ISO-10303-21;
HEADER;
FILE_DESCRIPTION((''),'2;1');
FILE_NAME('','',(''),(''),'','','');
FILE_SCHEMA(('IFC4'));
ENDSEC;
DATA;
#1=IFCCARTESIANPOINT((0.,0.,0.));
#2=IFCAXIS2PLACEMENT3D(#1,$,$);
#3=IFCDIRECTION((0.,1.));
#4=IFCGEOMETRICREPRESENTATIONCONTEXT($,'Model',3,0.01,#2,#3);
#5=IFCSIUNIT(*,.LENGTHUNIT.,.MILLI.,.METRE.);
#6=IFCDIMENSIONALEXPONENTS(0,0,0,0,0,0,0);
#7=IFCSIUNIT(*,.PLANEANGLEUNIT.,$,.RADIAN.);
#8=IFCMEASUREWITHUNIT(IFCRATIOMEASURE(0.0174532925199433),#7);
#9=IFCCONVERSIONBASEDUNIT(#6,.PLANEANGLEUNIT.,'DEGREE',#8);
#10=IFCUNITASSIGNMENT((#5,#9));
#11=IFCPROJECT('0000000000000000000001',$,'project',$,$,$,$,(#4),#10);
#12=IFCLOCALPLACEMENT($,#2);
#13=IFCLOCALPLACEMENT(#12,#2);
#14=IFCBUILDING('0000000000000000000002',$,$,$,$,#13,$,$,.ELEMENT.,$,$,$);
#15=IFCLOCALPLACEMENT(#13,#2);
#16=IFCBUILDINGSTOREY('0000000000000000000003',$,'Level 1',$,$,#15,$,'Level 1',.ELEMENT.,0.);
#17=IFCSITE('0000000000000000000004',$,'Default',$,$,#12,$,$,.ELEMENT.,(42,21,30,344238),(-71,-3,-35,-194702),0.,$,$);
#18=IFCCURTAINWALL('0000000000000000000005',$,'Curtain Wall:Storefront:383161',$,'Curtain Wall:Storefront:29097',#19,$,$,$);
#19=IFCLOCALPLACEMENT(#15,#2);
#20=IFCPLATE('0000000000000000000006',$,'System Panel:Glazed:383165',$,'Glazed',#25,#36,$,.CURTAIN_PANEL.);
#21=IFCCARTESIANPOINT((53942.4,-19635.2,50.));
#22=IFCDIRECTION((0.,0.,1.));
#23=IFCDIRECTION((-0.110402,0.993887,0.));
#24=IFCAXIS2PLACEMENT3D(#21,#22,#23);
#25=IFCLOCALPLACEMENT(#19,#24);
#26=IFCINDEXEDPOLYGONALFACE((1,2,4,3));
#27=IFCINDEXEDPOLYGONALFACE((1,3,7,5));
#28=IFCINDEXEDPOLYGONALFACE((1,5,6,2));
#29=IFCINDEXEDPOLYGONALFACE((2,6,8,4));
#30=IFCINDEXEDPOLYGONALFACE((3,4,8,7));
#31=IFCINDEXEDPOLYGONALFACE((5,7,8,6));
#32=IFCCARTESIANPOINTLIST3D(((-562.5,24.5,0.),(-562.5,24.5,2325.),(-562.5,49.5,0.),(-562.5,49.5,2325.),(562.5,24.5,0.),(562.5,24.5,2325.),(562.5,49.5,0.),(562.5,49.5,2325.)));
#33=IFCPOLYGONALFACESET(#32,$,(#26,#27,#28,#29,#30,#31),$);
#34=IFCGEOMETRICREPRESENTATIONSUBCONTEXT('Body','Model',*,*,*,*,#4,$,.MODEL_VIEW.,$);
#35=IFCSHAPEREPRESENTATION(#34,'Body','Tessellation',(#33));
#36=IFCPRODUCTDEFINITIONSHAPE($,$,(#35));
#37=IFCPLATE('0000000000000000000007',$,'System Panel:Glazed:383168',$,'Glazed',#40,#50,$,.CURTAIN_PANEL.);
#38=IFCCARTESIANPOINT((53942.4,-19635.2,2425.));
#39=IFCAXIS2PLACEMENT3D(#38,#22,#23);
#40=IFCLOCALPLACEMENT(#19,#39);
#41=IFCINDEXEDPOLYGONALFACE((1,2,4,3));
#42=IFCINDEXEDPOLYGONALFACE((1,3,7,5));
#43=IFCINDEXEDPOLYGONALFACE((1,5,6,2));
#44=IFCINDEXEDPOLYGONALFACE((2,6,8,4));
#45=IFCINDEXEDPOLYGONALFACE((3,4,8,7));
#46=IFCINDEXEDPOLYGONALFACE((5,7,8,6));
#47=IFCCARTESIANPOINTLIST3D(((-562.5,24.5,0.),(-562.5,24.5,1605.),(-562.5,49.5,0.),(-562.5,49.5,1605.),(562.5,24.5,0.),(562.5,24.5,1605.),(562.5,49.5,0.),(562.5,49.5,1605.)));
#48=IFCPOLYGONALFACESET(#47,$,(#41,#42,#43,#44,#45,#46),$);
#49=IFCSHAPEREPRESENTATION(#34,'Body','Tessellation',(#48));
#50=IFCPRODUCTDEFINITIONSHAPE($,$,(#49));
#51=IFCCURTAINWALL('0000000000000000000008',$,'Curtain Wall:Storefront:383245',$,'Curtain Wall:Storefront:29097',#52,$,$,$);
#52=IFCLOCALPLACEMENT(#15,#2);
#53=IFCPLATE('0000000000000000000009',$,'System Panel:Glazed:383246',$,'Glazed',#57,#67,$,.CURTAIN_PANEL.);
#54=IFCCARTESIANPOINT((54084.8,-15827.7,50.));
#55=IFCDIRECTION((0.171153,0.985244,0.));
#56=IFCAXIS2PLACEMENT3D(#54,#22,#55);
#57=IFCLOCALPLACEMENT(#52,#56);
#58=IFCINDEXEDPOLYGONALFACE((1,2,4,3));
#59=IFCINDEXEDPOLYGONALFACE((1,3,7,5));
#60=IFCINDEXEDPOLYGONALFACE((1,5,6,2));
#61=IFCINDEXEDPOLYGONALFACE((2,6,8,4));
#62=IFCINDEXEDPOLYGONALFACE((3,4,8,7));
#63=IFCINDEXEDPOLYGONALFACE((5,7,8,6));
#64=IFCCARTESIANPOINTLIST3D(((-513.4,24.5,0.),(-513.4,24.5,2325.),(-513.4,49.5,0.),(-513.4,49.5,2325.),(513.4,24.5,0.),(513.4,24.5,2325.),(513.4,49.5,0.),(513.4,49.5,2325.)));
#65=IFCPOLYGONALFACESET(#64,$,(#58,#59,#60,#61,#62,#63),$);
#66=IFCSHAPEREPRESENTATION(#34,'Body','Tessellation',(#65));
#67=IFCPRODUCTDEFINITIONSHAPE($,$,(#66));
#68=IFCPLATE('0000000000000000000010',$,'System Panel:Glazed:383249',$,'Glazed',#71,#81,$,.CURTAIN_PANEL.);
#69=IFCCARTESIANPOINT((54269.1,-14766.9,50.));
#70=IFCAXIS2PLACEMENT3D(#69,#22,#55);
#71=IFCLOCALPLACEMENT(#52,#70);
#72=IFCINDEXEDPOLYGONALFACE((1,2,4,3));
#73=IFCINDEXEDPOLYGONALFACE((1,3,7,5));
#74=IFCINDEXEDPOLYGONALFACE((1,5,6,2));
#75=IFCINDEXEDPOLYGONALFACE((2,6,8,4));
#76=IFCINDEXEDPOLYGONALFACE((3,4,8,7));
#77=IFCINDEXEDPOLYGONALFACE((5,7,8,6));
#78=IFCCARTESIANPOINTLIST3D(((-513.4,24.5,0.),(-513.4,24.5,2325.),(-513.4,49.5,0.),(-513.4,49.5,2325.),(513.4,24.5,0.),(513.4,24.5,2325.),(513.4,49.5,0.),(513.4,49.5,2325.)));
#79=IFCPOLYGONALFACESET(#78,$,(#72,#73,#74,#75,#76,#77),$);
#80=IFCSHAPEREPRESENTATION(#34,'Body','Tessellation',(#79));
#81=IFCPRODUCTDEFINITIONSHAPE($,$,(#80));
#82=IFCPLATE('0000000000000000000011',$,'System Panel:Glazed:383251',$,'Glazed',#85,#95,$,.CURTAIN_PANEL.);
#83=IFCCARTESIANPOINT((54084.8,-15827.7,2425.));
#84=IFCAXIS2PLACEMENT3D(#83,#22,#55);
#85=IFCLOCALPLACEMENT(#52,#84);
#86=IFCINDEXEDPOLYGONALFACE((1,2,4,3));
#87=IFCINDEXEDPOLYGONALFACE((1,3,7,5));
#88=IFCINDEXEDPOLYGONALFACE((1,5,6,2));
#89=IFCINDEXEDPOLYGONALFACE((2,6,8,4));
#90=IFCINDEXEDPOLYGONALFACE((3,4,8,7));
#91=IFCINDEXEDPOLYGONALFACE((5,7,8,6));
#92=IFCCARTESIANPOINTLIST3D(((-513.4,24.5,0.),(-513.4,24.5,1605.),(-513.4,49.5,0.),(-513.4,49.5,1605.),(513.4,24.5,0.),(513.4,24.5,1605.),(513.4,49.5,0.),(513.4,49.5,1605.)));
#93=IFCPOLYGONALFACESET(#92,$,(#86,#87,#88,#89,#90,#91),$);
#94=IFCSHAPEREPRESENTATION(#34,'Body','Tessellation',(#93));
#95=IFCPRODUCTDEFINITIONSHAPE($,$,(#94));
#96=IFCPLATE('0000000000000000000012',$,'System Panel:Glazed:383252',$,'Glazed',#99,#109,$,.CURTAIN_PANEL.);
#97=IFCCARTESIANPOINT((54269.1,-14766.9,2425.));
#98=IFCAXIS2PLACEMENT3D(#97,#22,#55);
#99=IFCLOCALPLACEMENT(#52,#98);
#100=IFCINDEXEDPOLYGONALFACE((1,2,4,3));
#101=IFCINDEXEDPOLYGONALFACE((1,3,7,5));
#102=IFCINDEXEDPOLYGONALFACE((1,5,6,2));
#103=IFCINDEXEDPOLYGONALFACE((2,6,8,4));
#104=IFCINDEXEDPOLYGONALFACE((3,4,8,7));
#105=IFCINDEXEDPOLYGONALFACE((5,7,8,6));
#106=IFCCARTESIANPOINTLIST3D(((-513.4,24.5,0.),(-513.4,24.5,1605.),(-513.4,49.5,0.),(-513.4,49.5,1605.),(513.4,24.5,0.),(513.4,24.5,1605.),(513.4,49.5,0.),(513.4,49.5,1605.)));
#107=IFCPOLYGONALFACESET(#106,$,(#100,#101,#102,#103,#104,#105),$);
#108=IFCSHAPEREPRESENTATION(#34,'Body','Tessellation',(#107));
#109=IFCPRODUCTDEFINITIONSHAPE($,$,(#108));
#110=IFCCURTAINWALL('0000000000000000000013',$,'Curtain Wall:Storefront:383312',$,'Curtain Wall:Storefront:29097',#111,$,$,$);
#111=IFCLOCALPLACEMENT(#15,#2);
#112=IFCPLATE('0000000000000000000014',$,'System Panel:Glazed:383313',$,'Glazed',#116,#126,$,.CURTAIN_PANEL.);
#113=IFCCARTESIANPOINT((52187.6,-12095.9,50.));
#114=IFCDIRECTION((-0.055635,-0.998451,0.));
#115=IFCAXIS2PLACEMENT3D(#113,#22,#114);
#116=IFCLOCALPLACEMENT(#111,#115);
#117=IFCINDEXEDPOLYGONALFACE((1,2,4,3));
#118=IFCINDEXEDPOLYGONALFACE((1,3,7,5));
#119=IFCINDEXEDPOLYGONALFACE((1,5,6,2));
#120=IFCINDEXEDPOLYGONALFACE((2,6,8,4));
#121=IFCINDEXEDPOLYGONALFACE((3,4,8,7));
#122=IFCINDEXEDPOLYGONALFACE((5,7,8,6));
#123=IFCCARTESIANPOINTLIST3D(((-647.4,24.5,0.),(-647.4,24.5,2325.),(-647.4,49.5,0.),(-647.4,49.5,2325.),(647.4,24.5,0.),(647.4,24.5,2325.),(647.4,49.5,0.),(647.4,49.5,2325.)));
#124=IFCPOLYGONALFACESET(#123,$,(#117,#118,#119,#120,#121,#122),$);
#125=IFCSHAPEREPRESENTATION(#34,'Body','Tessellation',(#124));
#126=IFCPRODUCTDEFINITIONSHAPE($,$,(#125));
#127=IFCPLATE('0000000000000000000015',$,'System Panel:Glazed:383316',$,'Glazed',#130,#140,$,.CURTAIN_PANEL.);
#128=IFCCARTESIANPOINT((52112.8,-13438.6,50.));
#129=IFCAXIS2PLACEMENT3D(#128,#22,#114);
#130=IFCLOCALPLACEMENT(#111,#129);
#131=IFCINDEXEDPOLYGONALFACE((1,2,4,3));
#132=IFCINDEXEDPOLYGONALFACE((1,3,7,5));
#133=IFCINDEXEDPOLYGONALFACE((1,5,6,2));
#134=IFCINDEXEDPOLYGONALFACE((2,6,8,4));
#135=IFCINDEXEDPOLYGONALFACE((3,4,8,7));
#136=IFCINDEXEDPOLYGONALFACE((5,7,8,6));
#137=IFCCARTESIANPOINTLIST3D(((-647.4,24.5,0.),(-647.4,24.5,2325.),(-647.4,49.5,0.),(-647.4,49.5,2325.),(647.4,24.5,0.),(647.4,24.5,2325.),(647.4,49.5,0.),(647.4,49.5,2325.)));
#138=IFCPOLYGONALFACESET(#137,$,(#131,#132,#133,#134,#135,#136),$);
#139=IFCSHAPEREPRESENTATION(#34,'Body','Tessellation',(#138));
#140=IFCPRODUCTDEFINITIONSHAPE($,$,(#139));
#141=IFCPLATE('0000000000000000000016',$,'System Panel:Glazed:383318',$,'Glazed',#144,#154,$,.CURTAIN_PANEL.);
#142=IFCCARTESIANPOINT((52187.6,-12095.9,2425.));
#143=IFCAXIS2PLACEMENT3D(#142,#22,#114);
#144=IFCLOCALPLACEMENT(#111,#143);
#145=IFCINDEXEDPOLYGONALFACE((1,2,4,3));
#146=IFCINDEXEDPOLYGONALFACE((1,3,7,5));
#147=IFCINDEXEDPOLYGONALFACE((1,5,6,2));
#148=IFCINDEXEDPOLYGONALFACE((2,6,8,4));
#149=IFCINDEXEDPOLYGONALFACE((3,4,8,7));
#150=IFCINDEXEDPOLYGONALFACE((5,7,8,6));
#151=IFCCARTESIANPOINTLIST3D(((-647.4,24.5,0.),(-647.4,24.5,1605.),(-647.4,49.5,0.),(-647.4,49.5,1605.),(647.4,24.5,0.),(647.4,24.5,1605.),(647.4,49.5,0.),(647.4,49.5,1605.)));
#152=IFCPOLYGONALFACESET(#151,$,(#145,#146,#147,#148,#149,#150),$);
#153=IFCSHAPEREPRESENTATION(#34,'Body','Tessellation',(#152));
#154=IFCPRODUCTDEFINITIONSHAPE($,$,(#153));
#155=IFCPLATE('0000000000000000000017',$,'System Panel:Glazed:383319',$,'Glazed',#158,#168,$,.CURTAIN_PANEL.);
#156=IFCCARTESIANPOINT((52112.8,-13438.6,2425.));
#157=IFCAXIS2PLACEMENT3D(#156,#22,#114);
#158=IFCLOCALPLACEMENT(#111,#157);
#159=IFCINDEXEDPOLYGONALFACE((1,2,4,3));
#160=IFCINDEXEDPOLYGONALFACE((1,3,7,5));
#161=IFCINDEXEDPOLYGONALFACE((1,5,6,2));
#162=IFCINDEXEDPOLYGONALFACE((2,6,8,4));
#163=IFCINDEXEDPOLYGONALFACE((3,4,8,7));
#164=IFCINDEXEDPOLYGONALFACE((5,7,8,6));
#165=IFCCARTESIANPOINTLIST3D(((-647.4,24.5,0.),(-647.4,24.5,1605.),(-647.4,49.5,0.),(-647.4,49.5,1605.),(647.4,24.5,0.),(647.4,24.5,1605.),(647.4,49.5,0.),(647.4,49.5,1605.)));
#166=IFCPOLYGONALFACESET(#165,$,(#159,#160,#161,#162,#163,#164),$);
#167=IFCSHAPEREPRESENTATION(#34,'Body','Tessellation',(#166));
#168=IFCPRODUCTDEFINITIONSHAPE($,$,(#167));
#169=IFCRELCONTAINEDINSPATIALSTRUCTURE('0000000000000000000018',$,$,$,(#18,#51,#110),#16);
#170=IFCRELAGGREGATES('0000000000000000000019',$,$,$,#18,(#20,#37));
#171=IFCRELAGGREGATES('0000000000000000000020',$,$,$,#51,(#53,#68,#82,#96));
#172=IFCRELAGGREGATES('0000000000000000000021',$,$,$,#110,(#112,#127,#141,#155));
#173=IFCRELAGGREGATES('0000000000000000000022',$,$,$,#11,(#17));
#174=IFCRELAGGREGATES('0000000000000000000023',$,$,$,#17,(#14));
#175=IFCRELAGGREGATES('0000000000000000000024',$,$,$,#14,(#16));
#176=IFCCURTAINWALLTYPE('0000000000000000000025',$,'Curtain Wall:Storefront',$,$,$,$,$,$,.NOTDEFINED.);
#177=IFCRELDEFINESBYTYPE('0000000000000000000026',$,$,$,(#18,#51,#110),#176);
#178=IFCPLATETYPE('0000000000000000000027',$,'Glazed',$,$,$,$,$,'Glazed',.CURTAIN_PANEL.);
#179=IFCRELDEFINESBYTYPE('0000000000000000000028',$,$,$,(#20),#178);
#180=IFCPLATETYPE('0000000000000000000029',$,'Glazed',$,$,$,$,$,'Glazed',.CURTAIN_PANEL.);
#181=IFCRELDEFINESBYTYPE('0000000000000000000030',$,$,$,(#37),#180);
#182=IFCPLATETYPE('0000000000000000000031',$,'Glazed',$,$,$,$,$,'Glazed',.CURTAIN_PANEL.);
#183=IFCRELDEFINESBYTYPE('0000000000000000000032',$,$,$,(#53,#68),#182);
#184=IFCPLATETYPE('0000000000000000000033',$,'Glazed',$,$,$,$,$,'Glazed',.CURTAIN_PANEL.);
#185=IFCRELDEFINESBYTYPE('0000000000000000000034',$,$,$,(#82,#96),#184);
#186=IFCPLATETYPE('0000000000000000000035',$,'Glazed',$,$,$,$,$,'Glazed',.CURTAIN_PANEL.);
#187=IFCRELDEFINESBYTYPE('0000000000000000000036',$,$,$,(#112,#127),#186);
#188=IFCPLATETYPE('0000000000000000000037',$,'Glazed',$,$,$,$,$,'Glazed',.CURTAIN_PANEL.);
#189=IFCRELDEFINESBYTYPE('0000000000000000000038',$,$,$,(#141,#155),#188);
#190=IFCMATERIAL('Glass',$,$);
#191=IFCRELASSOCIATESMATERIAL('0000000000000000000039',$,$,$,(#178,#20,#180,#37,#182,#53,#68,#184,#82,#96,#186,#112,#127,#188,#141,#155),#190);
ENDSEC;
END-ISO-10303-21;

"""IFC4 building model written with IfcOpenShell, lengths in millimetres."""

from ifc_helpers import new_model, entity, si_unit, converted_unit, direction, frame, frame_2d, origin, place, context, subcontext, project, spatial, rectangle, extrude, source, transform, mapped, material, type_object, type_shapes, element, aggregate, save


model = new_model("IFC4")

# Units and contexts
model_context = context("Model", 3, precision=0.01, world=origin(), true_north=direction((0.0, 1.0)))
body_context = subcontext(model_context, "Body", "Model", "MODEL_VIEW")
ifc_project = project(units=[si_unit("LENGTHUNIT", "METRE", prefix="MILLI"), converted_unit("PLANEANGLEUNIT", "DEGREE", entity("IfcRatioMeasure", 0.0174532925199433), si_unit("PLANEANGLEUNIT", "RADIAN"), dimensions=[0, 0, 0, 0, 0, 0, 0])], contexts=[model_context])

# Site, building, storey
site_placement = place(None, origin())
site = spatial("IfcSite", under=ifc_project, at=site_placement, Name="Default", CompositionType="ELEMENT", RefLatitude=(42, 21, 30, 344238), RefLongitude=(-71, -3, -35, -194702), RefElevation=0.0)
building_placement = place(site_placement, origin())
building = spatial("IfcBuilding", under=site, at=building_placement, CompositionType="ELEMENT")
storey_placement = place(building_placement, origin())
storey = spatial("IfcBuildingStorey", under=building, at=storey_placement, Name="Level 1", LongName="Level 1", CompositionType="ELEMENT", Elevation=0.0)

# Curtain walls, plates
curtain_wall_type = type_object("IfcCurtainWallType", Name="Curtain Wall:Storefront", PredefinedType="NOTDEFINED")
curtain_wall_1_placement = place(storey_placement, origin())
curtain_wall_1 = element("IfcCurtainWall", 1, at=curtain_wall_1_placement, inside=storey, type_object=curtain_wall_type, Name="Curtain Wall:Storefront:383161", ObjectType="Curtain Wall:Storefront:29097")
ifc_material_1 = material(Name="Glass")
plate_type_1 = type_object("IfcPlateType", Name="Glazed", ElementType="Glazed", PredefinedType="CURTAIN_PANEL", material=ifc_material_1)
shared_shape_1 = source(origin(), body_context, "Body", "SweptSolid", [
    extrude(rectangle(XDim=25.0, YDim=1125.0, at=frame_2d((0.0, 0.0), x_axis=(1.0, 0.0))), frame((0.0, 37.0, 0.0), z_axis=(0.0, 0.0, 1.0), x_axis=(0.0, 1.0, 0.0)), (0.0, 0.0, 1.0), 2325.0),
])
type_shapes(plate_type_1, [shared_shape_1])
plate_1_placement = place(curtain_wall_1_placement, frame((53942.4, -19635.2, 50.0), z_axis=(0.0, 0.0, 1.0), x_axis=(-0.110402, 0.993887, 0.0)))
plate_1 = element("IfcPlate", 2, at=plate_1_placement, type_object=plate_type_1, material=ifc_material_1, Name="System Panel:Glazed:383165", ObjectType="Glazed", PredefinedType="CURTAIN_PANEL", context=body_context, shape_type="MappedRepresentation", body=[
    mapped(shared_shape_1, transform((0.0, 0.0, 0.0), scale=1.0)),
])
plate_type_2 = type_object("IfcPlateType", Name="Glazed", ElementType="Glazed", PredefinedType="CURTAIN_PANEL", material=ifc_material_1)
shared_shape_2 = source(origin(), body_context, "Body", "SweptSolid", [
    extrude(rectangle(XDim=25.0, YDim=1125.0, at=frame_2d((0.0, 0.0), x_axis=(1.0, 0.0))), frame((0.0, 37.0, 0.0), z_axis=(0.0, 0.0, 1.0), x_axis=(0.0, 1.0, 0.0)), (0.0, 0.0, 1.0), 1605.0),
])
type_shapes(plate_type_2, [shared_shape_2])
plate_2_placement = place(curtain_wall_1_placement, frame((53942.4, -19635.2, 2425.0), z_axis=(0.0, 0.0, 1.0), x_axis=(-0.110402, 0.993887, 0.0)))
plate_2 = element("IfcPlate", 3, at=plate_2_placement, type_object=plate_type_2, material=ifc_material_1, Name="System Panel:Glazed:383168", ObjectType="Glazed", PredefinedType="CURTAIN_PANEL", context=body_context, shape_type="MappedRepresentation", body=[
    mapped(shared_shape_2, transform((0.0, 0.0, 0.0), scale=1.0)),
])
aggregate(curtain_wall_1, [plate_1, plate_2])
curtain_wall_2_placement = place(storey_placement, origin())
curtain_wall_2 = element("IfcCurtainWall", 4, at=curtain_wall_2_placement, inside=storey, type_object=curtain_wall_type, Name="Curtain Wall:Storefront:383245", ObjectType="Curtain Wall:Storefront:29097")
plate_type_3 = type_object("IfcPlateType", Name="Glazed", ElementType="Glazed", PredefinedType="CURTAIN_PANEL", material=ifc_material_1)
shared_shape_3 = source(origin(), body_context, "Body", "SweptSolid", [
    extrude(rectangle(XDim=25.0, YDim=1026.7, at=frame_2d((0.0, 0.0), x_axis=(1.0, 0.0))), frame((0.0, 37.0, 0.0), z_axis=(0.0, 0.0, 1.0), x_axis=(0.0, 1.0, 0.0)), (0.0, 0.0, 1.0), 2325.0),
])
type_shapes(plate_type_3, [shared_shape_3])
plate_3_placement = place(curtain_wall_2_placement, frame((54084.8, -15827.7, 50.0), z_axis=(0.0, 0.0, 1.0), x_axis=(0.171153, 0.985244, 0.0)))
plate_3 = element("IfcPlate", 5, at=plate_3_placement, type_object=plate_type_3, material=ifc_material_1, Name="System Panel:Glazed:383246", ObjectType="Glazed", PredefinedType="CURTAIN_PANEL", context=body_context, shape_type="MappedRepresentation", body=[
    mapped(shared_shape_3, transform((0.0, 0.0, 0.0), scale=1.0)),
])
plate_4_placement = place(curtain_wall_2_placement, frame((54269.1, -14766.9, 50.0), z_axis=(0.0, 0.0, 1.0), x_axis=(0.171153, 0.985244, 0.0)))
plate_4 = element("IfcPlate", 6, at=plate_4_placement, type_object=plate_type_3, material=ifc_material_1, Name="System Panel:Glazed:383249", ObjectType="Glazed", PredefinedType="CURTAIN_PANEL", context=body_context, shape_type="MappedRepresentation", body=[
    mapped(shared_shape_3, transform((0.0, 0.0, 0.0), scale=1.0)),
])
plate_type_4 = type_object("IfcPlateType", Name="Glazed", ElementType="Glazed", PredefinedType="CURTAIN_PANEL", material=ifc_material_1)
shared_shape_4 = source(origin(), body_context, "Body", "SweptSolid", [
    extrude(rectangle(XDim=25.0, YDim=1026.7, at=frame_2d((0.0, 0.0), x_axis=(1.0, 0.0))), frame((0.0, 37.0, 0.0), z_axis=(0.0, 0.0, 1.0), x_axis=(0.0, 1.0, 0.0)), (0.0, 0.0, 1.0), 1605.0),
])
type_shapes(plate_type_4, [shared_shape_4])
plate_5_placement = place(curtain_wall_2_placement, frame((54084.8, -15827.7, 2425.0), z_axis=(0.0, 0.0, 1.0), x_axis=(0.171153, 0.985244, 0.0)))
plate_5 = element("IfcPlate", 7, at=plate_5_placement, type_object=plate_type_4, material=ifc_material_1, Name="System Panel:Glazed:383251", ObjectType="Glazed", PredefinedType="CURTAIN_PANEL", context=body_context, shape_type="MappedRepresentation", body=[
    mapped(shared_shape_4, transform((0.0, 0.0, 0.0), scale=1.0)),
])
plate_6_placement = place(curtain_wall_2_placement, frame((54269.1, -14766.9, 2425.0), z_axis=(0.0, 0.0, 1.0), x_axis=(0.171153, 0.985244, 0.0)))
plate_6 = element("IfcPlate", 8, at=plate_6_placement, type_object=plate_type_4, material=ifc_material_1, Name="System Panel:Glazed:383252", ObjectType="Glazed", PredefinedType="CURTAIN_PANEL", context=body_context, shape_type="MappedRepresentation", body=[
    mapped(shared_shape_4, transform((0.0, 0.0, 0.0), scale=1.0)),
])
aggregate(curtain_wall_2, [plate_3, plate_4, plate_5, plate_6])
curtain_wall_3_placement = place(storey_placement, origin())
curtain_wall_3 = element("IfcCurtainWall", 9, at=curtain_wall_3_placement, inside=storey, type_object=curtain_wall_type, Name="Curtain Wall:Storefront:383312", ObjectType="Curtain Wall:Storefront:29097")
plate_type_5 = type_object("IfcPlateType", Name="Glazed", ElementType="Glazed", PredefinedType="CURTAIN_PANEL", material=ifc_material_1)
shared_shape_5 = source(origin(), body_context, "Body", "SweptSolid", [
    extrude(rectangle(XDim=25.0, YDim=1294.7, at=frame_2d((0.0, 0.0), x_axis=(1.0, 0.0))), frame((0.0, 37.0, 0.0), z_axis=(0.0, 0.0, 1.0), x_axis=(0.0, 1.0, 0.0)), (0.0, 0.0, 1.0), 2325.0),
])
type_shapes(plate_type_5, [shared_shape_5])
plate_7_placement = place(curtain_wall_3_placement, frame((52187.6, -12095.9, 50.0), z_axis=(0.0, 0.0, 1.0), x_axis=(-0.055635, -0.998451, 0.0)))
plate_7 = element("IfcPlate", 10, at=plate_7_placement, type_object=plate_type_5, material=ifc_material_1, Name="System Panel:Glazed:383313", ObjectType="Glazed", PredefinedType="CURTAIN_PANEL", context=body_context, shape_type="MappedRepresentation", body=[
    mapped(shared_shape_5, transform((0.0, 0.0, 0.0), scale=1.0)),
])
plate_8_placement = place(curtain_wall_3_placement, frame((52112.8, -13438.6, 50.0), z_axis=(0.0, 0.0, 1.0), x_axis=(-0.055635, -0.998451, 0.0)))
plate_8 = element("IfcPlate", 11, at=plate_8_placement, type_object=plate_type_5, material=ifc_material_1, Name="System Panel:Glazed:383316", ObjectType="Glazed", PredefinedType="CURTAIN_PANEL", context=body_context, shape_type="MappedRepresentation", body=[
    mapped(shared_shape_5, transform((0.0, 0.0, 0.0), scale=1.0)),
])
plate_type_6 = type_object("IfcPlateType", Name="Glazed", ElementType="Glazed", PredefinedType="CURTAIN_PANEL", material=ifc_material_1)
shared_shape_6 = source(origin(), body_context, "Body", "SweptSolid", [
    extrude(rectangle(XDim=25.0, YDim=1294.7, at=frame_2d((0.0, 0.0), x_axis=(1.0, 0.0))), frame((0.0, 37.0, 0.0), z_axis=(0.0, 0.0, 1.0), x_axis=(0.0, 1.0, 0.0)), (0.0, 0.0, 1.0), 1605.0),
])
type_shapes(plate_type_6, [shared_shape_6])
plate_9_placement = place(curtain_wall_3_placement, frame((52187.6, -12095.9, 2425.0), z_axis=(0.0, 0.0, 1.0), x_axis=(-0.055635, -0.998451, 0.0)))
plate_9 = element("IfcPlate", 12, at=plate_9_placement, type_object=plate_type_6, material=ifc_material_1, Name="System Panel:Glazed:383318", ObjectType="Glazed", PredefinedType="CURTAIN_PANEL", context=body_context, shape_type="MappedRepresentation", body=[
    mapped(shared_shape_6, transform((0.0, 0.0, 0.0), scale=1.0)),
])
plate_10_placement = place(curtain_wall_3_placement, frame((52112.8, -13438.6, 2425.0), z_axis=(0.0, 0.0, 1.0), x_axis=(-0.055635, -0.998451, 0.0)))
plate_10 = element("IfcPlate", 13, at=plate_10_placement, type_object=plate_type_6, material=ifc_material_1, Name="System Panel:Glazed:383319", ObjectType="Glazed", PredefinedType="CURTAIN_PANEL", context=body_context, shape_type="MappedRepresentation", body=[
    mapped(shared_shape_6, transform((0.0, 0.0, 0.0), scale=1.0)),
])
aggregate(curtain_wall_3, [plate_7, plate_8, plate_9, plate_10])

save(model, "model.ifc")
